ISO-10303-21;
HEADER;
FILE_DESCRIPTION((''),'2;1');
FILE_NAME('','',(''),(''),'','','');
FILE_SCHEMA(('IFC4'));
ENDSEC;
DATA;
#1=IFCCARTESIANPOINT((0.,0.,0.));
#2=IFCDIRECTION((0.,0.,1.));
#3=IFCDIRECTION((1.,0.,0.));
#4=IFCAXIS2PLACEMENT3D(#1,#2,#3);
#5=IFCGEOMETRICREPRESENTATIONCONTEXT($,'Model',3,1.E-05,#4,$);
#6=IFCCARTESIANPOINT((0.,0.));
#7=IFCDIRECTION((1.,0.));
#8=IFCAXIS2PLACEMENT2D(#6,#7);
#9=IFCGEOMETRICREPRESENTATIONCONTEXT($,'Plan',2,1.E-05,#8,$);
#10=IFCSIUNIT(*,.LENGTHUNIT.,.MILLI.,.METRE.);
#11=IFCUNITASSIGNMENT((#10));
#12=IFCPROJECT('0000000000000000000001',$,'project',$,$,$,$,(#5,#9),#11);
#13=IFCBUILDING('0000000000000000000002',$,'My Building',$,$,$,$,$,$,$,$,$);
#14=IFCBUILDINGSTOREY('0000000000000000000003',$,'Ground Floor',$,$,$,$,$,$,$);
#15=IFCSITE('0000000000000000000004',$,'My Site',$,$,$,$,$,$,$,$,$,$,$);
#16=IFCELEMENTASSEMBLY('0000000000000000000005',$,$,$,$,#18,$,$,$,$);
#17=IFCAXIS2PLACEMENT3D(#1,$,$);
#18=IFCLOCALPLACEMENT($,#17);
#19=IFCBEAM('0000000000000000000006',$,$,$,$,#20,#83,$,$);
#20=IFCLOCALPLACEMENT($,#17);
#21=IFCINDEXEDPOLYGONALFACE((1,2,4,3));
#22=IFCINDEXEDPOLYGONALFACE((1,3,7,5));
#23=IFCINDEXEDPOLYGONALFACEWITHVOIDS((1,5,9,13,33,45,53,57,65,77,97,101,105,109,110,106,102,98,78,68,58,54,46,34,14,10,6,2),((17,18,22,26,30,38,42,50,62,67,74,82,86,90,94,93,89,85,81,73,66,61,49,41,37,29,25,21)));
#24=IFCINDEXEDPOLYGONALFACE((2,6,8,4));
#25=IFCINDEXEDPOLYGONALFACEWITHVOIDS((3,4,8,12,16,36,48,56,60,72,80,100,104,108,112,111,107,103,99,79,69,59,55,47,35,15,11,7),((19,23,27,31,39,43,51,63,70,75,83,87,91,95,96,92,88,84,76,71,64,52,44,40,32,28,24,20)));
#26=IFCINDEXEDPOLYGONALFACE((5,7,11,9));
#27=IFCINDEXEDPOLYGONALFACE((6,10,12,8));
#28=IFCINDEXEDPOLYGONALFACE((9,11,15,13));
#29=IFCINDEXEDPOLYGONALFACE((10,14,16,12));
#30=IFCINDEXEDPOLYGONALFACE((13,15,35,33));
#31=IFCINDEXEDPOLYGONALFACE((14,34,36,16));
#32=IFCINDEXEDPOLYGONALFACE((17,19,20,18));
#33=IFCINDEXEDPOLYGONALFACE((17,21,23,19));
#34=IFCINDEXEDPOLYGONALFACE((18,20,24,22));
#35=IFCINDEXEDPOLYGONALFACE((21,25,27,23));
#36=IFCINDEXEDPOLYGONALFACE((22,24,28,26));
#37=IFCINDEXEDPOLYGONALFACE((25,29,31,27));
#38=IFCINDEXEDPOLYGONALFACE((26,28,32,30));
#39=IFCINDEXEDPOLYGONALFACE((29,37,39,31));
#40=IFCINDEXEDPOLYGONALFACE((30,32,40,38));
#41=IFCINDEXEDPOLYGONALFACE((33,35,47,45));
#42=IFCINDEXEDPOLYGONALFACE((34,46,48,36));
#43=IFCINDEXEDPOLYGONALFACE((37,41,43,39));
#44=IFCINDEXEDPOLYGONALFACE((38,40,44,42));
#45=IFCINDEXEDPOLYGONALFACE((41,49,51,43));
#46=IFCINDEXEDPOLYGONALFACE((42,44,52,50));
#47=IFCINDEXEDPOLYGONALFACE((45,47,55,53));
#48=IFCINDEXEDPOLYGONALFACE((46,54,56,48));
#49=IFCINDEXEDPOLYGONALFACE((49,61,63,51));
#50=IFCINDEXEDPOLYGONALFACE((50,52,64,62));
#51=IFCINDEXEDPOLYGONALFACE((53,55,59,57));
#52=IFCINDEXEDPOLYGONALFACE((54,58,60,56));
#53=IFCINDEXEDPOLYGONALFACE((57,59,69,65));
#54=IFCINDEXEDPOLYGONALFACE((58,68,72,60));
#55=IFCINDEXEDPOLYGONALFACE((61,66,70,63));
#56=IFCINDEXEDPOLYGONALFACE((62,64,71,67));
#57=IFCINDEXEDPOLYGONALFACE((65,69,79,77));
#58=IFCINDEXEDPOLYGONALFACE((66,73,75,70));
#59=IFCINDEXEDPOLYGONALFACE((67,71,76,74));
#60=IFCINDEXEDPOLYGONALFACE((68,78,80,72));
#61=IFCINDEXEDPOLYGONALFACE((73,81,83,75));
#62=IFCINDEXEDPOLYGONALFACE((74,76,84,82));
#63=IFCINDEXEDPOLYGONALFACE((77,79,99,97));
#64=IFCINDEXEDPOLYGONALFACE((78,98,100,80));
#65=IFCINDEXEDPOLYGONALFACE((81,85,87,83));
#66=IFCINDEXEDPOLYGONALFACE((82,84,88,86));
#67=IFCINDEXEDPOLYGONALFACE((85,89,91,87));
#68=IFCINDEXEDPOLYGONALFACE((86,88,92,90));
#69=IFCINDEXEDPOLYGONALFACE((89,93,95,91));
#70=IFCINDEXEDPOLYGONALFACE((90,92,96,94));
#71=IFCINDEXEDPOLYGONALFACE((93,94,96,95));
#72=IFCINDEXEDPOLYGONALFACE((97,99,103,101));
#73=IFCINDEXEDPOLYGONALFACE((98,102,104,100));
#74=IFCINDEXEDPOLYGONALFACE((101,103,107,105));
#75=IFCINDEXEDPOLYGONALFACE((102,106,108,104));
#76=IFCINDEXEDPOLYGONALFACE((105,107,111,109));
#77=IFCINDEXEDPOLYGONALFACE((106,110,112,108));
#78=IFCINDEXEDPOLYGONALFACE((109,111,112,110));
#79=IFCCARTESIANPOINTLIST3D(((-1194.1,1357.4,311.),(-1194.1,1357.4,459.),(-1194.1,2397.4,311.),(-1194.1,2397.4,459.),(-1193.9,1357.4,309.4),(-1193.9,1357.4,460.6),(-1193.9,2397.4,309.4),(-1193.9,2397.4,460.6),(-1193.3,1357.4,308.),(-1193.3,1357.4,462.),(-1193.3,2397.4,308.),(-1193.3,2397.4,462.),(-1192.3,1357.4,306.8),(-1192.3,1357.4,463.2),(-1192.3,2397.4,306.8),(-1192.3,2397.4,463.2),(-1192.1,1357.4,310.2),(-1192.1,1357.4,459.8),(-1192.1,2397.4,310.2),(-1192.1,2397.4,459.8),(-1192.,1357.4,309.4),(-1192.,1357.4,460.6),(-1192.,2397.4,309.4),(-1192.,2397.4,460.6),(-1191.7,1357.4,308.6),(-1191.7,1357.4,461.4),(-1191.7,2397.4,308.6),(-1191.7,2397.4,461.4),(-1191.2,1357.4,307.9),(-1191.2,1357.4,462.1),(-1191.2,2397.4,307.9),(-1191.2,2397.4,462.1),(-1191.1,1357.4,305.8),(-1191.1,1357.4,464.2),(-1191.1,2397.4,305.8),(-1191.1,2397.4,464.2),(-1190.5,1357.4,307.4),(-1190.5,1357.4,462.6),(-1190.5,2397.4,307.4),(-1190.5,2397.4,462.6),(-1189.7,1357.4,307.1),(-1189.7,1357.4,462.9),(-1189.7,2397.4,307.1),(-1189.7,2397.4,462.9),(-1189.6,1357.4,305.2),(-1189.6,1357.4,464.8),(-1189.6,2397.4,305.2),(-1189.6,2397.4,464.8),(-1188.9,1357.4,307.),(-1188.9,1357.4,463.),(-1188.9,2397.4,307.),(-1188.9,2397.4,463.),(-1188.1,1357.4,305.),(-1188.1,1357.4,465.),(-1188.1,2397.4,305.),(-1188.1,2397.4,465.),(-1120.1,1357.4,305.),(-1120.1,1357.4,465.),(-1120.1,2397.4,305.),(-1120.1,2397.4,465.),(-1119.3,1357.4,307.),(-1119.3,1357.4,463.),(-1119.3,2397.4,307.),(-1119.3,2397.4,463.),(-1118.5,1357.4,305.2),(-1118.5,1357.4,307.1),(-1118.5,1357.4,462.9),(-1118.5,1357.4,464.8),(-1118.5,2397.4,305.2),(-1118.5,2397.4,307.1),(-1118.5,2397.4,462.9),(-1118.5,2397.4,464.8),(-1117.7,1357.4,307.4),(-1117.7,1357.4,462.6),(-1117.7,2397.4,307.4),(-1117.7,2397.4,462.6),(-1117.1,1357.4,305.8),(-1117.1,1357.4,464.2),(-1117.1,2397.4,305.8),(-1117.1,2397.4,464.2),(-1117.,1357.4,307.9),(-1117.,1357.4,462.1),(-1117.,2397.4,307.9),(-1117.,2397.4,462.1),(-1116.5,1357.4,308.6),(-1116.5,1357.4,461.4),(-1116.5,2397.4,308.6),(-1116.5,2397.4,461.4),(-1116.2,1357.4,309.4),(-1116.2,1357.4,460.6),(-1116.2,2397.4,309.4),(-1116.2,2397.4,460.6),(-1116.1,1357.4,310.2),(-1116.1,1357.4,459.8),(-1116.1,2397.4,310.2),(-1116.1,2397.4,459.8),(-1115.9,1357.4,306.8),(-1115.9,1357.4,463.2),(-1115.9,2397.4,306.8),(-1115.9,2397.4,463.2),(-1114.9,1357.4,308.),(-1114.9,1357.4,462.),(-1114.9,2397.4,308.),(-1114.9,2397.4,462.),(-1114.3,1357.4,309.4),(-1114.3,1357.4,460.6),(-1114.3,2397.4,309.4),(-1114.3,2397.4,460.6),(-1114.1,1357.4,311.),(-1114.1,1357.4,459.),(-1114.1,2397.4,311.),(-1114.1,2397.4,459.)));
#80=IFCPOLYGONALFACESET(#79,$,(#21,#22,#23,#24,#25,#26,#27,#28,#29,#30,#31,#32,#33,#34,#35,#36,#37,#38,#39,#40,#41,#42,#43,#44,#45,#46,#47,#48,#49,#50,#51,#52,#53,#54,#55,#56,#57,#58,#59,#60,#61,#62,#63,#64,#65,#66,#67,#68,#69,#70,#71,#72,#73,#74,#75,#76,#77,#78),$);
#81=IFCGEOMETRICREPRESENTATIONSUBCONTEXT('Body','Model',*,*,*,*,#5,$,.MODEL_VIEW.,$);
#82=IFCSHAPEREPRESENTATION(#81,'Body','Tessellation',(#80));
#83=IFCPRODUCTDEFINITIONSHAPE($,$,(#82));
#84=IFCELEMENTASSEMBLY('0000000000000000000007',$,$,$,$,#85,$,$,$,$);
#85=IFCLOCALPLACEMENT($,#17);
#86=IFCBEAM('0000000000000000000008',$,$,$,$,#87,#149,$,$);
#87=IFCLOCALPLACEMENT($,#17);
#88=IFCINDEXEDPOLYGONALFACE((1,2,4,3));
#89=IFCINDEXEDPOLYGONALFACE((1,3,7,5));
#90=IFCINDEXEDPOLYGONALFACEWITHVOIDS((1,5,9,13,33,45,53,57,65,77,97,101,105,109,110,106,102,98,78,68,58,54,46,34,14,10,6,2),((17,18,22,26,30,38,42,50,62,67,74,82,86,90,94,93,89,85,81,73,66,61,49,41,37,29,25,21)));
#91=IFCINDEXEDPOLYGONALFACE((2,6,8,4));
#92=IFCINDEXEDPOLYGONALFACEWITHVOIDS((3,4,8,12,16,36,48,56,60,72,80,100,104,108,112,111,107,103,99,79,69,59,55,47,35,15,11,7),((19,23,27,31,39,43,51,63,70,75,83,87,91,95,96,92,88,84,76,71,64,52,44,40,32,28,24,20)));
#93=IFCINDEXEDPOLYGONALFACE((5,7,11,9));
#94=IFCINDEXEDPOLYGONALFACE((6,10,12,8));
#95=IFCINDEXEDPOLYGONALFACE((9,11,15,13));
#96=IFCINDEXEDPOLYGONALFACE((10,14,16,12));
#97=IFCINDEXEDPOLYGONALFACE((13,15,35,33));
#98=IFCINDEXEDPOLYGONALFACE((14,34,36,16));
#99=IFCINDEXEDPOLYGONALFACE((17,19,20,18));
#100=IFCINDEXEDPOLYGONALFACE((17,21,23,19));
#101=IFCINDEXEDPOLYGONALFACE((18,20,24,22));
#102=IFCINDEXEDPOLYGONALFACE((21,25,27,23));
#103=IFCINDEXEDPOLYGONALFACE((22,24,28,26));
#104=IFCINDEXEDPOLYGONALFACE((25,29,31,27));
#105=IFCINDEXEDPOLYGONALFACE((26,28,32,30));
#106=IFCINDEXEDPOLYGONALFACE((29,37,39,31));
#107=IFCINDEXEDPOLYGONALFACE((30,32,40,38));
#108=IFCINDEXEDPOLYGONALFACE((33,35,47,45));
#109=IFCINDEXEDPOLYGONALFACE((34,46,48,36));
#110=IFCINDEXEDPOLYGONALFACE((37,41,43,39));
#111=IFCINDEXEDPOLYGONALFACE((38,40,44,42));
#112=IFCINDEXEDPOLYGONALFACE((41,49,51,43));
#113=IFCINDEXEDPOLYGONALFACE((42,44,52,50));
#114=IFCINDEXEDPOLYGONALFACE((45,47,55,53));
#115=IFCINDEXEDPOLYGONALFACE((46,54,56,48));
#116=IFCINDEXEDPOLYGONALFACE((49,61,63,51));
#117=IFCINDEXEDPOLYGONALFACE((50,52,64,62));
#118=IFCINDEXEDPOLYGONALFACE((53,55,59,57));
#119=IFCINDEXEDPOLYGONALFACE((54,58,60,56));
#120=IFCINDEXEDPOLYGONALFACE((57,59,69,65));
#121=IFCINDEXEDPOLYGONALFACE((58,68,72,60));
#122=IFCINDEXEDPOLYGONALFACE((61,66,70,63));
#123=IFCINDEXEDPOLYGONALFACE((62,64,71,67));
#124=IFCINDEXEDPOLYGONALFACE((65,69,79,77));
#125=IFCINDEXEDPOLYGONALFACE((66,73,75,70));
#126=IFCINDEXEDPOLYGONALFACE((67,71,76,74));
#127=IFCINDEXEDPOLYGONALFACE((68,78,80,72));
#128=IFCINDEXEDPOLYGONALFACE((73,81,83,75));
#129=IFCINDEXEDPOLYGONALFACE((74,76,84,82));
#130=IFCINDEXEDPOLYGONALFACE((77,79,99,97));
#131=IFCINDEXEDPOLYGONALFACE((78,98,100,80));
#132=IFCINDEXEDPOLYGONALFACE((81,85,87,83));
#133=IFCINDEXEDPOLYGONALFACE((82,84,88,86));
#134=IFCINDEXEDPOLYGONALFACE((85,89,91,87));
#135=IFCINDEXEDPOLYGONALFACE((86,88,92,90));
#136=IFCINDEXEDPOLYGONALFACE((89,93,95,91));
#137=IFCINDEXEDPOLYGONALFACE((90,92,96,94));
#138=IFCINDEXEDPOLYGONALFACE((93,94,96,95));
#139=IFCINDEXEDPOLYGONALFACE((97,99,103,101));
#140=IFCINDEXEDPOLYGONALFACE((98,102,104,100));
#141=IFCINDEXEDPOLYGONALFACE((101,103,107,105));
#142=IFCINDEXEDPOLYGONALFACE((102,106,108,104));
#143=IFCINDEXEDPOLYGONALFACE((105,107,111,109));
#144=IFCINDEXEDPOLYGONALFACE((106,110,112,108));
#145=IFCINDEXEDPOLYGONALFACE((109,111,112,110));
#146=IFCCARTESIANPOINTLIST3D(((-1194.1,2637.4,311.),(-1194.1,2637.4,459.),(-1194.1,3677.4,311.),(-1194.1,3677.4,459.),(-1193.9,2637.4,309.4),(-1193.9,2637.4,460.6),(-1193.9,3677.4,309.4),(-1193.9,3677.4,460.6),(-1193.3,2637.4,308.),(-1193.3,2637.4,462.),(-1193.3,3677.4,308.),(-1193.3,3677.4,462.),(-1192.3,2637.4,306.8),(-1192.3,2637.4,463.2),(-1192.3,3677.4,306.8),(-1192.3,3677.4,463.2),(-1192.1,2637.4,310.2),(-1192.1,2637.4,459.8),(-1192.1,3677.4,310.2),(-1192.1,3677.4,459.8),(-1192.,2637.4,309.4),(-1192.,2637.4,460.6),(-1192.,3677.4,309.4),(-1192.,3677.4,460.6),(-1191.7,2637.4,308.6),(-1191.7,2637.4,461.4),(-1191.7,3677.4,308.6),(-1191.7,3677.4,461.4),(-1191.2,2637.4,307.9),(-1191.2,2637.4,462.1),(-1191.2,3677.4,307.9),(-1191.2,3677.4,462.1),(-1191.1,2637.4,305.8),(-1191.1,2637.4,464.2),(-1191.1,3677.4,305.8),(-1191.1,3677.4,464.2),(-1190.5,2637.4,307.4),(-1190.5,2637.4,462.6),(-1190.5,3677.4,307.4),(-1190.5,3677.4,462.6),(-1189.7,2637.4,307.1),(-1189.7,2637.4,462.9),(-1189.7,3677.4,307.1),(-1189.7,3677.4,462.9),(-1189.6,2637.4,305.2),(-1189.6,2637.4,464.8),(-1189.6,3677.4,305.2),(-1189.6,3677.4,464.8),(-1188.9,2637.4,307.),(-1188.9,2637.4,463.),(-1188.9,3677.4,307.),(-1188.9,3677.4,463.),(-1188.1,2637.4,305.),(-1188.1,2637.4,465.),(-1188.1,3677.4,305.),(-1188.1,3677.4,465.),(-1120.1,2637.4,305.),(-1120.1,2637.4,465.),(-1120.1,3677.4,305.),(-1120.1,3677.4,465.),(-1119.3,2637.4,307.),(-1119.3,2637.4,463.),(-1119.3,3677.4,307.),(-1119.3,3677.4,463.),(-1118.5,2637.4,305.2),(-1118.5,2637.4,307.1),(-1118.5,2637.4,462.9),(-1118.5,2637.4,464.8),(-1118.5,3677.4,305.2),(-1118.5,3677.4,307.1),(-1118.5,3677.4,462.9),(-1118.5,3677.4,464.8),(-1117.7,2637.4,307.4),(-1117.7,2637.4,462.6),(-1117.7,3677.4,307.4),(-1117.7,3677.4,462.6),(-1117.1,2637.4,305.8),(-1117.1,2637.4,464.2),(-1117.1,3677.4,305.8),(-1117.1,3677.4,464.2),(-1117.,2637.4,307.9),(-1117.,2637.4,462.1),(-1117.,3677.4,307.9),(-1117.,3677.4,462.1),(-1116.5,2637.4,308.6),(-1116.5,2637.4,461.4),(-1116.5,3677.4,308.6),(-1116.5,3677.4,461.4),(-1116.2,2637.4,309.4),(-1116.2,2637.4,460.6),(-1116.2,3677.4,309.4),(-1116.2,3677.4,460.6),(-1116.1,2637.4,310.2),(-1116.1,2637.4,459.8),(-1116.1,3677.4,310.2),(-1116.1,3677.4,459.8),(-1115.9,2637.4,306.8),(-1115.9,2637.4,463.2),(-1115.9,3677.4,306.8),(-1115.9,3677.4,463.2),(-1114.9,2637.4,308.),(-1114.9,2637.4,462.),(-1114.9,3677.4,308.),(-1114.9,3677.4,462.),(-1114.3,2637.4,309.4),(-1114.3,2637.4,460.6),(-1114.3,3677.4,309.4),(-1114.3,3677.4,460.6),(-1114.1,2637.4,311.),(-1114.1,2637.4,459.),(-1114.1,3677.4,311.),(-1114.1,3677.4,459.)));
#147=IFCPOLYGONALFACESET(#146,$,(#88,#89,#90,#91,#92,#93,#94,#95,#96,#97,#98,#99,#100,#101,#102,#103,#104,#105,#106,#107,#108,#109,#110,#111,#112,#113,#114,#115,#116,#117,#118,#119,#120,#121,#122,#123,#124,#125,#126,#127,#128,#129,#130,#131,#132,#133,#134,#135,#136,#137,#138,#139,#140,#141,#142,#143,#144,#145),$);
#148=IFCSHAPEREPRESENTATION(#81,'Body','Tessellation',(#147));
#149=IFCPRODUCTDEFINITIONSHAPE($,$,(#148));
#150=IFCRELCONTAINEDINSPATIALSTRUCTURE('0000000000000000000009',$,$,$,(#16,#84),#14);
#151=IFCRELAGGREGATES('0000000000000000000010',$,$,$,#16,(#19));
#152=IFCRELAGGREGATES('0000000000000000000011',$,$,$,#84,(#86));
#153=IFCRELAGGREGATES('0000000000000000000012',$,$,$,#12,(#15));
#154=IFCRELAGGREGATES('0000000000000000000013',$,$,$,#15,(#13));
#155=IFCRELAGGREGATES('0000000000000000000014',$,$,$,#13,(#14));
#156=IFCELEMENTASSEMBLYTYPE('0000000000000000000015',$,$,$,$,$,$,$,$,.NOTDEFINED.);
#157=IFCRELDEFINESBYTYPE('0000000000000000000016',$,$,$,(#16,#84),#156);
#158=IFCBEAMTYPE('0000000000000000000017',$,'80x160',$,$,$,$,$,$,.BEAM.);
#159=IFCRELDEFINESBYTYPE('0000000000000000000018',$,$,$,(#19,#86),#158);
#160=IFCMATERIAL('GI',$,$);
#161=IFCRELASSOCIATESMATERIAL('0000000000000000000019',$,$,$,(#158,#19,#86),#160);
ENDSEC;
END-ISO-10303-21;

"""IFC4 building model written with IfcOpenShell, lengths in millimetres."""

from ifc_helpers import new_model, si_unit, frame, origin_with_axes, origin_2d_with_axis, place, context, subcontext, project, spatial, hollow_rectangle, extrude, material, material_profile, profile_set, profile_usage, type_object, element, aggregate, save


model = new_model("IFC4")

# Units and contexts
model_context = context("Model", 3, precision=1e-05, world=origin_with_axes())
plan_context = context("Plan", 2, precision=1e-05, world=origin_2d_with_axis())
body_context = subcontext(model_context, "Body", "Model", "MODEL_VIEW")
ifc_project = project(units=[si_unit("LENGTHUNIT", "METRE", prefix="MILLI")], contexts=[model_context, plan_context])

# Site, building, storey
site = spatial("IfcSite", under=ifc_project, Name="My Site")
building = spatial("IfcBuilding", under=site, Name="My Building")
storey = spatial("IfcBuildingStorey", under=building, Name="Ground Floor")

# Shared definitions
ifc_material = material(Name="GI")

# Element assemblies, beams
element_assembly_type_1 = type_object("IfcElementAssemblyType", PredefinedType="NOTDEFINED")
ifc_material_profile_1 = material_profile(ifc_material, hollow_rectangle(XDim=80.0, YDim=160.0, WallThickness=2.0, InnerFilletRadius=3.2, OuterFilletRadius=6.0))
ifc_profile_set_1 = profile_set([ifc_material_profile_1], Name="80x160 GI Rectangular Hollow")
beam_type = type_object("IfcBeamType", Name="80x160", PredefinedType="BEAM", material=ifc_profile_set_1)
assembly_1_placement = place(None, frame((-1154.1, 1277.4, 385.0), z_axis=(0.0, 1.0, 0.0), x_axis=(1.0, 0.0, 0.0)))
assembly_1 = element("IfcElementAssembly", 1, at=assembly_1_placement, inside=storey, type_object=element_assembly_type_1)
ifc_profile_usage_1 = profile_usage(ifc_profile_set_1)
beam_1_placement = place(assembly_1_placement, frame((0.0, 0.0, 80.0), z_axis=(0.0, 0.0, 1.0), x_axis=(1.0, 0.0, 0.0)))
beam_1 = element("IfcBeam", 2, at=beam_1_placement, type_object=beam_type, material=ifc_profile_usage_1, context=body_context, shape_type="SweptSolid", body=[
    extrude(hollow_rectangle(XDim=80.0, YDim=160.0, WallThickness=2.0, InnerFilletRadius=3.2, OuterFilletRadius=6.0), origin_with_axes(), (0.0, 0.0, 1.0), 1040.0),
])
aggregate(assembly_1, [beam_1])
assembly_2_placement = place(None, frame((-1154.1, 2557.4, 385.0), z_axis=(0.0, 1.0, 0.0), x_axis=(1.0, 0.0, 0.0)))
assembly_2 = element("IfcElementAssembly", 3, at=assembly_2_placement, inside=storey, type_object=element_assembly_type_1)
ifc_profile_usage_2 = profile_usage(ifc_profile_set_1)
beam_2_placement = place(assembly_2_placement, frame((0.0, 0.0, 80.0), z_axis=(0.0, 0.0, 1.0), x_axis=(1.0, 0.0, 0.0)))
beam_2 = element("IfcBeam", 4, at=beam_2_placement, type_object=beam_type, material=ifc_profile_usage_2, context=body_context, shape_type="SweptSolid", body=[
    extrude(hollow_rectangle(XDim=80.0, YDim=160.0, WallThickness=2.0, InnerFilletRadius=3.2, OuterFilletRadius=6.0), origin_with_axes(), (0.0, 0.0, 1.0), 1040.0),
])
aggregate(assembly_2, [beam_2])

save(model, "model.ifc")
